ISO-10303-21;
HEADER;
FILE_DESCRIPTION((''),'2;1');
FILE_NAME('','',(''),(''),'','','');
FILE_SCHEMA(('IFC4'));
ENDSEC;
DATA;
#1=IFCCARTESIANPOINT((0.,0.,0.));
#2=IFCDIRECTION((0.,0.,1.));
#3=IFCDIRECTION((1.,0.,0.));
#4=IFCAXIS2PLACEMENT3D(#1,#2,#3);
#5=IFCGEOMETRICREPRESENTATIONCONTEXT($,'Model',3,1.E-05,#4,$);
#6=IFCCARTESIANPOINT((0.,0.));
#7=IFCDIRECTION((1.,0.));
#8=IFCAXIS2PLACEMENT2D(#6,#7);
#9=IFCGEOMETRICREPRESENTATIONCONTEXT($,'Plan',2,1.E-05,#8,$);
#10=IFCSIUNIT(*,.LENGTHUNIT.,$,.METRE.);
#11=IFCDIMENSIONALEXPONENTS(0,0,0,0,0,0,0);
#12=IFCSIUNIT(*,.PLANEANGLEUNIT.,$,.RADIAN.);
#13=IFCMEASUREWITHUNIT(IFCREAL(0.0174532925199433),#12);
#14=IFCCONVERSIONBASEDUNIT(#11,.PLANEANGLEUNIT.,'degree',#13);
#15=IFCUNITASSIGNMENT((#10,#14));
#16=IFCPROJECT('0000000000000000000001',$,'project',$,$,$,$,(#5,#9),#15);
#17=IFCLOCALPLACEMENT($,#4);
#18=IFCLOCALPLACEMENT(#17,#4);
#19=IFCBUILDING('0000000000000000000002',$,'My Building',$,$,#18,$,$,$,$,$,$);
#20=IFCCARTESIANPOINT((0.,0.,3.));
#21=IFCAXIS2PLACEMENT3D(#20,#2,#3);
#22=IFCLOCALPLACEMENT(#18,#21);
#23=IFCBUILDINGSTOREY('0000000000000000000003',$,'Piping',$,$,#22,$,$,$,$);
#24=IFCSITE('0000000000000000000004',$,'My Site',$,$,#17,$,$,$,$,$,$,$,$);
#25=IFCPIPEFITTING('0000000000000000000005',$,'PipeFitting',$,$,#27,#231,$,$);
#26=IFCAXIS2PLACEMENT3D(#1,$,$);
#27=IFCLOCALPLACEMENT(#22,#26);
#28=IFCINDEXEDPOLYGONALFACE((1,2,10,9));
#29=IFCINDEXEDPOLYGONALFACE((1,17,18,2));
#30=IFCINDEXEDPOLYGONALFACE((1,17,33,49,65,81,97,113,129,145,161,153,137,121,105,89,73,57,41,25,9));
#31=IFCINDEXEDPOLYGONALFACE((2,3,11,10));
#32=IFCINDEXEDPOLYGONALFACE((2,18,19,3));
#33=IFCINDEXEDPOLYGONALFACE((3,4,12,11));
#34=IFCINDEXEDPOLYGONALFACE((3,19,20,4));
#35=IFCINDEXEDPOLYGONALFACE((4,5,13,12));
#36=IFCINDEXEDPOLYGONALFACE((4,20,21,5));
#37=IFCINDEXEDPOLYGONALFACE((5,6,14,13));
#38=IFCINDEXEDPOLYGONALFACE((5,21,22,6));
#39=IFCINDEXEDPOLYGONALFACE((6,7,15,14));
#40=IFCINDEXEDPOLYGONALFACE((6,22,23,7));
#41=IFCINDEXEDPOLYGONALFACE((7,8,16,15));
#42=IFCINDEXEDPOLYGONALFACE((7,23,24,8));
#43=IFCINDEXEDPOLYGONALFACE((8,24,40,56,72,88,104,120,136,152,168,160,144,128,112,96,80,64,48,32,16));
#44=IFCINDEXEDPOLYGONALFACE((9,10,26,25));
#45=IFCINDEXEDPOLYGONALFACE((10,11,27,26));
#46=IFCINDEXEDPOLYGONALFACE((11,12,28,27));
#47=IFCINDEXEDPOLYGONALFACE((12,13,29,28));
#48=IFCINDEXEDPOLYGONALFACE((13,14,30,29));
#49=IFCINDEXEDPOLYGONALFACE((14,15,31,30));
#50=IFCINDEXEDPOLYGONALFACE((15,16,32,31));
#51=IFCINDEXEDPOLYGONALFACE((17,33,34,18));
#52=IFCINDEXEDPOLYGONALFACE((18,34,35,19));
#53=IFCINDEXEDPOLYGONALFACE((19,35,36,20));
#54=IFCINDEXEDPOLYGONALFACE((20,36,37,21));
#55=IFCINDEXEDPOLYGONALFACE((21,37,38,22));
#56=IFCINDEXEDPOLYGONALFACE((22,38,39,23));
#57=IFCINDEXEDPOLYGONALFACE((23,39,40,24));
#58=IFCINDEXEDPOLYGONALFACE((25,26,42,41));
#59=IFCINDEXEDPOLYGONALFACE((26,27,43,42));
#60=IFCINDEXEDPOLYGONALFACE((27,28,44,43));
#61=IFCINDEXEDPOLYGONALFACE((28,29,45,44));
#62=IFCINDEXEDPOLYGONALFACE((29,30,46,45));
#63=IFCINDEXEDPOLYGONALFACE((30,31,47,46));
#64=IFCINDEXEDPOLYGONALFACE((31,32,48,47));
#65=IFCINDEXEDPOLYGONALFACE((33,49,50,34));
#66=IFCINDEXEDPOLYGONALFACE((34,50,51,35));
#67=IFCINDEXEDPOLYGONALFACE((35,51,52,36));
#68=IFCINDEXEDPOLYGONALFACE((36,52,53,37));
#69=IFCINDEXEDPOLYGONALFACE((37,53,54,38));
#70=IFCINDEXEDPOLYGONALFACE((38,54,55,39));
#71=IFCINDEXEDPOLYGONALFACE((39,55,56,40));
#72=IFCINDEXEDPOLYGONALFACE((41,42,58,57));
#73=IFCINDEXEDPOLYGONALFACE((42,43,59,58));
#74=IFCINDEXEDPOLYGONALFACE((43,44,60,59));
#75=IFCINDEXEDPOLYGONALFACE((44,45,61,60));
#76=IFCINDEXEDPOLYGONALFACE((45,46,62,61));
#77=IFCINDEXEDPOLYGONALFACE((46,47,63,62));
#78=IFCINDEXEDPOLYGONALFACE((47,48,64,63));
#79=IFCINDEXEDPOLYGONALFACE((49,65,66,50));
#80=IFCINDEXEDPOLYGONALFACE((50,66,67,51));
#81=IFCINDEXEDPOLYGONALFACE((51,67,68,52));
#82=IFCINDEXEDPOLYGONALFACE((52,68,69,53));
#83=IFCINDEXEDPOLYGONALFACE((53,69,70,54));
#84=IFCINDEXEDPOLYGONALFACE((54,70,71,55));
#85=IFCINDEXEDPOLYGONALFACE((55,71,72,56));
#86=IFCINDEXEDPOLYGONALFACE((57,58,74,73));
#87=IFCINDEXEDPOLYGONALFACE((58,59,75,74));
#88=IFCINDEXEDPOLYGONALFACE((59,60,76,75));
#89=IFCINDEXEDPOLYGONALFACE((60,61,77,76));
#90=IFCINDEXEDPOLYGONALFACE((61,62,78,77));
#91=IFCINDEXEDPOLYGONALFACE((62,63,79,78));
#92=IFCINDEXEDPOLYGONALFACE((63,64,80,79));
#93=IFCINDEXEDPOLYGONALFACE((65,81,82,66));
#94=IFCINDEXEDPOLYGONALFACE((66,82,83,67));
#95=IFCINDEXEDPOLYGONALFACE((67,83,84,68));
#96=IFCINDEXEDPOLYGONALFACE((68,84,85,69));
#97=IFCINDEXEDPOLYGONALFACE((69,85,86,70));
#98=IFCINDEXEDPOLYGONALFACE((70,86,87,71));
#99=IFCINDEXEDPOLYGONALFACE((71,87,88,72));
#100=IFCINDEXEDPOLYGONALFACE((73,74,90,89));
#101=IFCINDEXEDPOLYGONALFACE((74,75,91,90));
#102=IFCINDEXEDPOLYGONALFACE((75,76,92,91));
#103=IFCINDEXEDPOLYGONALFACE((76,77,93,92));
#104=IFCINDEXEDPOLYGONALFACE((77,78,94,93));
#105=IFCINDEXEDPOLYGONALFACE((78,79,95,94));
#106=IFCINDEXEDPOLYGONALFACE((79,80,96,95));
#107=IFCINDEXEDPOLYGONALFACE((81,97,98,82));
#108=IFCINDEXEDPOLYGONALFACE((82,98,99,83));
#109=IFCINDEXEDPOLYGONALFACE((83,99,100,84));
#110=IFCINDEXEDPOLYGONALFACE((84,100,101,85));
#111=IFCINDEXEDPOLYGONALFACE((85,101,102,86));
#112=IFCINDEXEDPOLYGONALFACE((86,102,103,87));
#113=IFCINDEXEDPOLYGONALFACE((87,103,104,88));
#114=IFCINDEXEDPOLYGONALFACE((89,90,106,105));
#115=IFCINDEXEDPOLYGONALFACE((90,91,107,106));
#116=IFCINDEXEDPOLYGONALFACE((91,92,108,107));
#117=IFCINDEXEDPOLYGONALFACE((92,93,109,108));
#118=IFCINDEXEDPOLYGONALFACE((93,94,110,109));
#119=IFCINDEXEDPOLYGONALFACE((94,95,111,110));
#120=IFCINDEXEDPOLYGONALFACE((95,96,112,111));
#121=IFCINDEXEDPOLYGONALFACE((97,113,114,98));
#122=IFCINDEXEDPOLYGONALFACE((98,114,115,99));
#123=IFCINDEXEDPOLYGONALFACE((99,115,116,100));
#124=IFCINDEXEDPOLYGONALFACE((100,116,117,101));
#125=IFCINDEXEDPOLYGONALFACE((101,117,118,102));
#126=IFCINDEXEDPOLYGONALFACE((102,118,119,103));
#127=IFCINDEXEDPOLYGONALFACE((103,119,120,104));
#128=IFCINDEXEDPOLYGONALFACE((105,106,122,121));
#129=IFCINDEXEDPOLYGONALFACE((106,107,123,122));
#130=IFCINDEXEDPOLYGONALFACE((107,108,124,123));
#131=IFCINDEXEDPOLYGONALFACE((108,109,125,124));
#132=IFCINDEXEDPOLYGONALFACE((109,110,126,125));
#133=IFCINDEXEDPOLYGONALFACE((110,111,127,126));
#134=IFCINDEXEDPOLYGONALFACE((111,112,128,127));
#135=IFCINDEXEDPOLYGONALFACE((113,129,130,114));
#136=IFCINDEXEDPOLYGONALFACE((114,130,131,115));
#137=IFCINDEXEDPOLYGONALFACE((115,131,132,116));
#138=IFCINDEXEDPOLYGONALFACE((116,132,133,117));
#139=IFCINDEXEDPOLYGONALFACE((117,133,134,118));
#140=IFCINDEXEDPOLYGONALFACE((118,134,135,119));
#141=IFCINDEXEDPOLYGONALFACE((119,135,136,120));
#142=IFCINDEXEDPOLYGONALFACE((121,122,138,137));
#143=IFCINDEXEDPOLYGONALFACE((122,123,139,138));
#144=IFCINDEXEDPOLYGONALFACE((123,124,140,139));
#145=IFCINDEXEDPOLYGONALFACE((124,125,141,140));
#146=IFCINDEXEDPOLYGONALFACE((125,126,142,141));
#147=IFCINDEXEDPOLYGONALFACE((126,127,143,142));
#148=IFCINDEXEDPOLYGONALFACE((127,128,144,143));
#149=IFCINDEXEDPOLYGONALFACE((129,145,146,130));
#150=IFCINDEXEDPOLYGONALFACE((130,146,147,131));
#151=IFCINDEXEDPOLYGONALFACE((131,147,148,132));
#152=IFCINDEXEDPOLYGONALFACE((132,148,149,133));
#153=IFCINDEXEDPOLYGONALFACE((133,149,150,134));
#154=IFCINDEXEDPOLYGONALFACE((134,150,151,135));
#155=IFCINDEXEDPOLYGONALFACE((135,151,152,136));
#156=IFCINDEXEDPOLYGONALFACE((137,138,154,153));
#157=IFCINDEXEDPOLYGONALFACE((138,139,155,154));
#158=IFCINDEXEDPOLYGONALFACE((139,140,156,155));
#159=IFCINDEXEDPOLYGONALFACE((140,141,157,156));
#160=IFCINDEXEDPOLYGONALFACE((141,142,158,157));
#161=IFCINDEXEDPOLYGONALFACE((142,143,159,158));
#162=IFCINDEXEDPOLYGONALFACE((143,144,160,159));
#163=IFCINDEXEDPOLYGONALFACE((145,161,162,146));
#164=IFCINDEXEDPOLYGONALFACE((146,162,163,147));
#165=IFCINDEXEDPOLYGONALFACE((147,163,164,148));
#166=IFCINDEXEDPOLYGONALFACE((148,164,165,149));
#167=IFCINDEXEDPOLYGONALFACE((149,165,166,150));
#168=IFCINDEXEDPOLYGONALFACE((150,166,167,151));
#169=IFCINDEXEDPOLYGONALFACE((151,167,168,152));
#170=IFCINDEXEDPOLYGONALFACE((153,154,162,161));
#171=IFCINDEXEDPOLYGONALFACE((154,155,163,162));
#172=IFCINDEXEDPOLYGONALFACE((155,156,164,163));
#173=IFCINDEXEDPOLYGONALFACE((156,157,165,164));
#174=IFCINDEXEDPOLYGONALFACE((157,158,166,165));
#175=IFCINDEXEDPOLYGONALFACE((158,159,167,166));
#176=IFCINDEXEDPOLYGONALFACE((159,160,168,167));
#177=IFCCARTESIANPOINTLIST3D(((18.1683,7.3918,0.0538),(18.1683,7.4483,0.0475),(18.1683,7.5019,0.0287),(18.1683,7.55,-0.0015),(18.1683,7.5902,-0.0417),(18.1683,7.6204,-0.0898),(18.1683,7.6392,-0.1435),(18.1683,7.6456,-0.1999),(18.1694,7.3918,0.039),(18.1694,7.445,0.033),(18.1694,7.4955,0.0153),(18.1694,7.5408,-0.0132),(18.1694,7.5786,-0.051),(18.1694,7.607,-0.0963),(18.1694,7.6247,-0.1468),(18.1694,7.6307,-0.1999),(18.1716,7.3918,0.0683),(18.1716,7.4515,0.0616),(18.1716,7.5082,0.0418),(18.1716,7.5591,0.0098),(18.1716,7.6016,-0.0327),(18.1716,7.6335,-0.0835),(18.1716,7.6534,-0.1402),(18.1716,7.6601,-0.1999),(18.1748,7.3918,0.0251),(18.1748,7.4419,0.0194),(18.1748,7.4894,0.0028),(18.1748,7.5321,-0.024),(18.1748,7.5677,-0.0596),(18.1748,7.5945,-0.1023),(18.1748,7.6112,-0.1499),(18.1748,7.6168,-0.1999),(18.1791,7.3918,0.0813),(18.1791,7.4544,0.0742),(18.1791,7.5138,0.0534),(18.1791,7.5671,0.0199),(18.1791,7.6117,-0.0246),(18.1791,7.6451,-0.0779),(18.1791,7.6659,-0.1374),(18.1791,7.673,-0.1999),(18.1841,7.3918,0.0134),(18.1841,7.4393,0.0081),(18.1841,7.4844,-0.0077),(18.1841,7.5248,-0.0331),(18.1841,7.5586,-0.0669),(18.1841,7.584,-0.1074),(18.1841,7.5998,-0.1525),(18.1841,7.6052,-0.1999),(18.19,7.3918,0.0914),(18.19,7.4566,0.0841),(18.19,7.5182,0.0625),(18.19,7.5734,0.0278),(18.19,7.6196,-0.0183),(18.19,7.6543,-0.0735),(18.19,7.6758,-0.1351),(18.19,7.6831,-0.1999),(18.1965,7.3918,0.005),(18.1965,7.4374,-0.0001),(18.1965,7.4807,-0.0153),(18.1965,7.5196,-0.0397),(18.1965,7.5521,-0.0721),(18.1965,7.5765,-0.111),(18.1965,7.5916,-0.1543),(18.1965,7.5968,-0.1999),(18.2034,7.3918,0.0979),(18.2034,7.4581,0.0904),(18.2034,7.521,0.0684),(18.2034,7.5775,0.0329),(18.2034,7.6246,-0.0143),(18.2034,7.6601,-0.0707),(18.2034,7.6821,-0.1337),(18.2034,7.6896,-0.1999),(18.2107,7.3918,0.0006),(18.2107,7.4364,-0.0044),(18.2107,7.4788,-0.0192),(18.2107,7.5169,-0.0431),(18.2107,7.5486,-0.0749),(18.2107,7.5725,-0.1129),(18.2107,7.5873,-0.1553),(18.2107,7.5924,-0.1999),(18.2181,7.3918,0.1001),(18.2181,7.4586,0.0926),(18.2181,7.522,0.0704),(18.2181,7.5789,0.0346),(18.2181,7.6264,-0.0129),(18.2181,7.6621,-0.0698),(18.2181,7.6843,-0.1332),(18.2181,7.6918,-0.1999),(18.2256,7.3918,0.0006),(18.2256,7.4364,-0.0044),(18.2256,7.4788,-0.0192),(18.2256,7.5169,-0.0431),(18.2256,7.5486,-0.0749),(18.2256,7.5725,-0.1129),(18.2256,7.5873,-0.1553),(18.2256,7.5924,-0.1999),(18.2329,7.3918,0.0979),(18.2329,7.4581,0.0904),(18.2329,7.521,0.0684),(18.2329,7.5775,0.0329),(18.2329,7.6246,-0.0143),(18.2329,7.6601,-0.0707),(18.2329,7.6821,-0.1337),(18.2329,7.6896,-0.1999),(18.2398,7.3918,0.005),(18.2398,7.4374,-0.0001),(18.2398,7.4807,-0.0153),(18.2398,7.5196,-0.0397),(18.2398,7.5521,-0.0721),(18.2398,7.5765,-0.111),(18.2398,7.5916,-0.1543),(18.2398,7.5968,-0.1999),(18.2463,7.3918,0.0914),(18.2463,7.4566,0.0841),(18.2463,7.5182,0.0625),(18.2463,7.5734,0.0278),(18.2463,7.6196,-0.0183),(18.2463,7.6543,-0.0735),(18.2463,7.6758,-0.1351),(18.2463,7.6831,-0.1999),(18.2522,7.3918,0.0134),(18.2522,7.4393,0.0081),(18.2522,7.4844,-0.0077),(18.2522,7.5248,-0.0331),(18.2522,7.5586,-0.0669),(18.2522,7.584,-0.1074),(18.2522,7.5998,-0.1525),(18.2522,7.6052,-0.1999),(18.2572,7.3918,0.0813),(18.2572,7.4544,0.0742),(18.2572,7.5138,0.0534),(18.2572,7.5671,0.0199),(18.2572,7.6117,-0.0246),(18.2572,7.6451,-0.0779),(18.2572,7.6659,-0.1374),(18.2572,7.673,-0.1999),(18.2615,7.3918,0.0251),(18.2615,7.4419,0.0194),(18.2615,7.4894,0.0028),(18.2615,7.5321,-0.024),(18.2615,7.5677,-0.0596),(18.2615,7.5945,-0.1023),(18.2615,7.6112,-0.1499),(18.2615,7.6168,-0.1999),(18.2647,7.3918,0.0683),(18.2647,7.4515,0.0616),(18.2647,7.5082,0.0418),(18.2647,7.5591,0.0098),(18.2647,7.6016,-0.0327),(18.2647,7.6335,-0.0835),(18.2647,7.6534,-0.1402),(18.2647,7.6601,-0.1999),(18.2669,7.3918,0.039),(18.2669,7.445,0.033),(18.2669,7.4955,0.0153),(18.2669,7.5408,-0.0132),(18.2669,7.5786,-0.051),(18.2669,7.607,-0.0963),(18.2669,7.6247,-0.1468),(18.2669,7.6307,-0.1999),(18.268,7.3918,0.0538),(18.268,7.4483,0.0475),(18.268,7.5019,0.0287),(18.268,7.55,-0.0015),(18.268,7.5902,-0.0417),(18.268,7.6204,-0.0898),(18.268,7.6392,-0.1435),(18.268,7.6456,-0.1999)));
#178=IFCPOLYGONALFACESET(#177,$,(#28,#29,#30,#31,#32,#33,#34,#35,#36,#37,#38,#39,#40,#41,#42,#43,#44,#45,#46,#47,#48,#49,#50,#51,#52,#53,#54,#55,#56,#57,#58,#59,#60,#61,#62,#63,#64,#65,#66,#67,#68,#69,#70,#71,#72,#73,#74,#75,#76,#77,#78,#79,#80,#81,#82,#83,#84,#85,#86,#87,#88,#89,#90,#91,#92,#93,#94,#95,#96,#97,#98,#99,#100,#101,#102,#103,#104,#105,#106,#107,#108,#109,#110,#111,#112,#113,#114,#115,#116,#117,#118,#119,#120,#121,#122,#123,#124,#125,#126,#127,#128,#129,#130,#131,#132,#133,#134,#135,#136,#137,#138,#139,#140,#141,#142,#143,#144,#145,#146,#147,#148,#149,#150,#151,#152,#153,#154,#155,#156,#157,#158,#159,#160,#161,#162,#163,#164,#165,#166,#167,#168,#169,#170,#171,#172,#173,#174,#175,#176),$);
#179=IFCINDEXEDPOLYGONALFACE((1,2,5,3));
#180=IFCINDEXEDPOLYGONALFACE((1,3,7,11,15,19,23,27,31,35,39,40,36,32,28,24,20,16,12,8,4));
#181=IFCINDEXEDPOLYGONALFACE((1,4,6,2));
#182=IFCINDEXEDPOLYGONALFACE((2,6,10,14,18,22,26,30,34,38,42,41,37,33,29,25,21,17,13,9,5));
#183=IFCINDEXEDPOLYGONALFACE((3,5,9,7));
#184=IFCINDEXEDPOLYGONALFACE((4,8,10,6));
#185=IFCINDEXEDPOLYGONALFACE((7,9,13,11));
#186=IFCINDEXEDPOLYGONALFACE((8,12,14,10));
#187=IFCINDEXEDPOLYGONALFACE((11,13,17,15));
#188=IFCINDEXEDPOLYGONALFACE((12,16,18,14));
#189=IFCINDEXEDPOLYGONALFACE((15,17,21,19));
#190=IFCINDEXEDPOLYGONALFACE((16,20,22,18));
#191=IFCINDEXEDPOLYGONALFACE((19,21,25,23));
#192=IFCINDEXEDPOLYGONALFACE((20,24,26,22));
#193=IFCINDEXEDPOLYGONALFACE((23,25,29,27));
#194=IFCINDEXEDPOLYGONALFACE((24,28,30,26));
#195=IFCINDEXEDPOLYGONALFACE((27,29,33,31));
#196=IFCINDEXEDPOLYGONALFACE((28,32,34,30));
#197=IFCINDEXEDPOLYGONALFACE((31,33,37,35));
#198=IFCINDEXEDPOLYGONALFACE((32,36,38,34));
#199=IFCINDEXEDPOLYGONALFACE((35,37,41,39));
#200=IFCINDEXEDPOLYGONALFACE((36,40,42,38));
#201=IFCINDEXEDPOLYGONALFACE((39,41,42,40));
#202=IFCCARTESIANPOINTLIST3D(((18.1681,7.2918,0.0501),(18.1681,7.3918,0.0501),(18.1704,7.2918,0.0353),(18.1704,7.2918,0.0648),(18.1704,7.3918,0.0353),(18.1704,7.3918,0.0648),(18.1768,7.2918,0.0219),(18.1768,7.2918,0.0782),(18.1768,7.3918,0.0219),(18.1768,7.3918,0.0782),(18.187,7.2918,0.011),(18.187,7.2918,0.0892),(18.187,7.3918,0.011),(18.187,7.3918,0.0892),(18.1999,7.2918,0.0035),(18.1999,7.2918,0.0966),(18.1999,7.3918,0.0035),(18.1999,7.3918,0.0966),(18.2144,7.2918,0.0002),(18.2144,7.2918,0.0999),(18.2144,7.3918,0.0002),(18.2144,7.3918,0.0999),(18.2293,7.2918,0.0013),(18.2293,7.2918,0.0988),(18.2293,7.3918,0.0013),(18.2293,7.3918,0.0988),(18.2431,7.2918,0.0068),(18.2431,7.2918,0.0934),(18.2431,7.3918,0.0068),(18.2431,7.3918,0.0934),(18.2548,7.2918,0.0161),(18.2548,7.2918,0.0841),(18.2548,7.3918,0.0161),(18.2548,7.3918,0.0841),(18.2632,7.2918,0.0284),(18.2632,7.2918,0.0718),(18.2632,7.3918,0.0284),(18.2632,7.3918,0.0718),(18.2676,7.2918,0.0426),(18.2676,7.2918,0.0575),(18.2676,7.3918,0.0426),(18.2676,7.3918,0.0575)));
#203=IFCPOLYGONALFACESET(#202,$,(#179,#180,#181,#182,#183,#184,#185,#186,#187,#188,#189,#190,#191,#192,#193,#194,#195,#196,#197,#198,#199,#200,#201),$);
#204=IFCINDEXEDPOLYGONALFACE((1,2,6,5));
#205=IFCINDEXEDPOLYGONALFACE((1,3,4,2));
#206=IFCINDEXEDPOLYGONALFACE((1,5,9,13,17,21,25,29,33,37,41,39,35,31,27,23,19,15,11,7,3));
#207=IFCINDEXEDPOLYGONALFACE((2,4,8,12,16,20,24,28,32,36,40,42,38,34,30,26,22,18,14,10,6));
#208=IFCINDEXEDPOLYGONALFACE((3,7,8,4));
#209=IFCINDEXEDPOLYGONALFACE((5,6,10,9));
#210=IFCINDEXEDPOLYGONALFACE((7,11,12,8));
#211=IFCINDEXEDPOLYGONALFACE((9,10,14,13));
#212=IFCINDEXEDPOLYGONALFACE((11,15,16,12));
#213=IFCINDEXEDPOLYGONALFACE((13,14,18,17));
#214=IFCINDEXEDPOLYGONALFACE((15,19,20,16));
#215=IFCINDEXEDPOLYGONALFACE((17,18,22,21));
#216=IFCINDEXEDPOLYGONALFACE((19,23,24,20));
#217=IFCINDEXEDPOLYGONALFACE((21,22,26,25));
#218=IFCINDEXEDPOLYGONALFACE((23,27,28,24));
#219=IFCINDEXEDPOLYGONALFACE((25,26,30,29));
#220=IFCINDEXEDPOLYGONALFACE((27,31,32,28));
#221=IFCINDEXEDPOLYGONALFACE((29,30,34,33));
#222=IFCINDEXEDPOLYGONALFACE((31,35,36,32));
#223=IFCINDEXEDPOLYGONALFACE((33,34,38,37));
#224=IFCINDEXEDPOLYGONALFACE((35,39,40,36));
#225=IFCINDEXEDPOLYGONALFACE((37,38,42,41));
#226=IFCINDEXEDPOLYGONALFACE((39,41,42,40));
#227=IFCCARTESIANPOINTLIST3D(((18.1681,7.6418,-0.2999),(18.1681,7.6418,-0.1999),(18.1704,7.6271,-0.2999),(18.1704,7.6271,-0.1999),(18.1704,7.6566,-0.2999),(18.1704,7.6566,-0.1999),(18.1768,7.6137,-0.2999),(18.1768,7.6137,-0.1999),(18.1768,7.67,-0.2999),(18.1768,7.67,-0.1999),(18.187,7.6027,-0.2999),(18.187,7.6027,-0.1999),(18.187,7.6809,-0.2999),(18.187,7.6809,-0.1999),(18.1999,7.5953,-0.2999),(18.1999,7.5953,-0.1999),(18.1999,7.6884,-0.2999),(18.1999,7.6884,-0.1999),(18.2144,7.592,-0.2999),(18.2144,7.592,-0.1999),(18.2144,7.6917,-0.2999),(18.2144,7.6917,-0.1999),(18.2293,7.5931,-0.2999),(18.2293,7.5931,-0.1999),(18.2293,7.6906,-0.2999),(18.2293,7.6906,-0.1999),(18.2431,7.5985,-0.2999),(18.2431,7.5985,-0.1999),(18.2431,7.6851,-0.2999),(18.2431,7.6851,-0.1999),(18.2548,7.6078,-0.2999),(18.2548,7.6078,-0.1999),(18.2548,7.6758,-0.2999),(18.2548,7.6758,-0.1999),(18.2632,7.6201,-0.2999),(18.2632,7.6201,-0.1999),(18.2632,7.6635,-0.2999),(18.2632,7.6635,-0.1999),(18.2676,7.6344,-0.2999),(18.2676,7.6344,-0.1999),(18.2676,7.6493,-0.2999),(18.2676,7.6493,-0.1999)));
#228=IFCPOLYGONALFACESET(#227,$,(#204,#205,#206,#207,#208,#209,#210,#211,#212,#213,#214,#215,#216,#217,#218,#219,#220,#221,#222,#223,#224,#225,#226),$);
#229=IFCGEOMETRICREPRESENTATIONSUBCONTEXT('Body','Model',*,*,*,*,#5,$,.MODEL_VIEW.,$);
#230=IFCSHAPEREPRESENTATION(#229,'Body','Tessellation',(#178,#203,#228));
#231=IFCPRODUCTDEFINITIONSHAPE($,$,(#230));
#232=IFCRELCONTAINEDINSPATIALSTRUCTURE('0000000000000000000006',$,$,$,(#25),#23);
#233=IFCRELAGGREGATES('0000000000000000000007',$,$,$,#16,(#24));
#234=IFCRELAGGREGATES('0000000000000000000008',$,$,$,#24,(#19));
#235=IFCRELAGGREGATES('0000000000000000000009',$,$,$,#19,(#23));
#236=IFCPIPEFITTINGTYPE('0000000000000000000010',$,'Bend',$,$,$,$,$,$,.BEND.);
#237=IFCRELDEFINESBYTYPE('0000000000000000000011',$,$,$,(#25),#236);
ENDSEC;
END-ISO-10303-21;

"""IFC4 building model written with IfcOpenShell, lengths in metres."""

from ifc_helpers import new_model, entity, si_unit, converted_unit, frame, origin_with_axes, origin_2d_with_axis, place, context, subcontext, project, spatial, circle, extrude, source, transform, mapped, type_object, type_shapes, element, save


model = new_model("IFC4")

# Units and contexts
model_context = context("Model", 3, precision=1e-05, world=origin_with_axes())
plan_context = context("Plan", 2, precision=1e-05, world=origin_2d_with_axis())
body_context = subcontext(model_context, "Body", "Model", "MODEL_VIEW")
ifc_project = project(units=[si_unit("LENGTHUNIT", "METRE"), converted_unit("PLANEANGLEUNIT", "degree", entity("IfcReal", 0.0174532925199433), si_unit("PLANEANGLEUNIT", "RADIAN"), dimensions=[0, 0, 0, 0, 0, 0, 0])], contexts=[model_context, plan_context])

# Site, building, storey
site_placement = place(None, origin_with_axes())
site = spatial("IfcSite", under=ifc_project, at=site_placement, Name="My Site")
building_placement = place(site_placement, origin_with_axes())
building = spatial("IfcBuilding", under=site, at=building_placement, Name="My Building")
storey_placement = place(building_placement, frame((0.0, 0.0, 3.0), z_axis=(0.0, 0.0, 1.0), x_axis=(1.0, 0.0, 0.0)))
storey = spatial("IfcBuildingStorey", under=building, at=storey_placement, Name="Piping")

# Pipe fitting
pipe_fitting_type_1 = type_object("IfcPipeFittingType", Name="Bend", PredefinedType="BEND")
shared_shape = source(origin_with_axes(), body_context, "Body", "SolidModel", [
    entity("IfcSweptDiskSolid", entity("IfcIndexedPolyCurve", entity("IfcCartesianPointList3D", [[0.0, 0.0, 0.1], [0.0, -0.0732, 0.2768], [0.0, -0.25, 0.35]]), [entity("IfcArcIndex", [1, 2, 3])]), 0.05),
    extrude(circle(Radius=0.05), origin_with_axes(), (0.0, 0.0, 1.0), 0.1),
    extrude(circle(Radius=0.05), frame((0.0, -0.25, 0.35), z_axis=(0.0, -1.0, -0.000003), x_axis=(1.0, 0.0, 0.0)), (0.0, 0.0, 1.0), 0.1),
])
type_shapes(pipe_fitting_type_1, [shared_shape])
for number, where, z_axis, x_axis, name in (
    (1, (18.2181, 7.2918, 0.0501), (0.0, 1.0, 0.0), (-1.0, 0.0, 0.0), "PipeFitting"),
):
    element("IfcPipeFitting", number, at=place(storey_placement, frame(where, z_axis=z_axis, x_axis=x_axis)), inside=storey, type_object=pipe_fitting_type_1, Name=name, context=body_context, shape_type="MappedRepresentation", body=[
        mapped(shared_shape, transform((0.0, 0.0, 0.0), x_axis=(1.0, 0.0, 0.0), y_axis=(0.0, 1.0, 0.0), z_axis=(0.0, 0.0, 1.0), scale=1.0)),
    ])

save(model, "model.ifc")
